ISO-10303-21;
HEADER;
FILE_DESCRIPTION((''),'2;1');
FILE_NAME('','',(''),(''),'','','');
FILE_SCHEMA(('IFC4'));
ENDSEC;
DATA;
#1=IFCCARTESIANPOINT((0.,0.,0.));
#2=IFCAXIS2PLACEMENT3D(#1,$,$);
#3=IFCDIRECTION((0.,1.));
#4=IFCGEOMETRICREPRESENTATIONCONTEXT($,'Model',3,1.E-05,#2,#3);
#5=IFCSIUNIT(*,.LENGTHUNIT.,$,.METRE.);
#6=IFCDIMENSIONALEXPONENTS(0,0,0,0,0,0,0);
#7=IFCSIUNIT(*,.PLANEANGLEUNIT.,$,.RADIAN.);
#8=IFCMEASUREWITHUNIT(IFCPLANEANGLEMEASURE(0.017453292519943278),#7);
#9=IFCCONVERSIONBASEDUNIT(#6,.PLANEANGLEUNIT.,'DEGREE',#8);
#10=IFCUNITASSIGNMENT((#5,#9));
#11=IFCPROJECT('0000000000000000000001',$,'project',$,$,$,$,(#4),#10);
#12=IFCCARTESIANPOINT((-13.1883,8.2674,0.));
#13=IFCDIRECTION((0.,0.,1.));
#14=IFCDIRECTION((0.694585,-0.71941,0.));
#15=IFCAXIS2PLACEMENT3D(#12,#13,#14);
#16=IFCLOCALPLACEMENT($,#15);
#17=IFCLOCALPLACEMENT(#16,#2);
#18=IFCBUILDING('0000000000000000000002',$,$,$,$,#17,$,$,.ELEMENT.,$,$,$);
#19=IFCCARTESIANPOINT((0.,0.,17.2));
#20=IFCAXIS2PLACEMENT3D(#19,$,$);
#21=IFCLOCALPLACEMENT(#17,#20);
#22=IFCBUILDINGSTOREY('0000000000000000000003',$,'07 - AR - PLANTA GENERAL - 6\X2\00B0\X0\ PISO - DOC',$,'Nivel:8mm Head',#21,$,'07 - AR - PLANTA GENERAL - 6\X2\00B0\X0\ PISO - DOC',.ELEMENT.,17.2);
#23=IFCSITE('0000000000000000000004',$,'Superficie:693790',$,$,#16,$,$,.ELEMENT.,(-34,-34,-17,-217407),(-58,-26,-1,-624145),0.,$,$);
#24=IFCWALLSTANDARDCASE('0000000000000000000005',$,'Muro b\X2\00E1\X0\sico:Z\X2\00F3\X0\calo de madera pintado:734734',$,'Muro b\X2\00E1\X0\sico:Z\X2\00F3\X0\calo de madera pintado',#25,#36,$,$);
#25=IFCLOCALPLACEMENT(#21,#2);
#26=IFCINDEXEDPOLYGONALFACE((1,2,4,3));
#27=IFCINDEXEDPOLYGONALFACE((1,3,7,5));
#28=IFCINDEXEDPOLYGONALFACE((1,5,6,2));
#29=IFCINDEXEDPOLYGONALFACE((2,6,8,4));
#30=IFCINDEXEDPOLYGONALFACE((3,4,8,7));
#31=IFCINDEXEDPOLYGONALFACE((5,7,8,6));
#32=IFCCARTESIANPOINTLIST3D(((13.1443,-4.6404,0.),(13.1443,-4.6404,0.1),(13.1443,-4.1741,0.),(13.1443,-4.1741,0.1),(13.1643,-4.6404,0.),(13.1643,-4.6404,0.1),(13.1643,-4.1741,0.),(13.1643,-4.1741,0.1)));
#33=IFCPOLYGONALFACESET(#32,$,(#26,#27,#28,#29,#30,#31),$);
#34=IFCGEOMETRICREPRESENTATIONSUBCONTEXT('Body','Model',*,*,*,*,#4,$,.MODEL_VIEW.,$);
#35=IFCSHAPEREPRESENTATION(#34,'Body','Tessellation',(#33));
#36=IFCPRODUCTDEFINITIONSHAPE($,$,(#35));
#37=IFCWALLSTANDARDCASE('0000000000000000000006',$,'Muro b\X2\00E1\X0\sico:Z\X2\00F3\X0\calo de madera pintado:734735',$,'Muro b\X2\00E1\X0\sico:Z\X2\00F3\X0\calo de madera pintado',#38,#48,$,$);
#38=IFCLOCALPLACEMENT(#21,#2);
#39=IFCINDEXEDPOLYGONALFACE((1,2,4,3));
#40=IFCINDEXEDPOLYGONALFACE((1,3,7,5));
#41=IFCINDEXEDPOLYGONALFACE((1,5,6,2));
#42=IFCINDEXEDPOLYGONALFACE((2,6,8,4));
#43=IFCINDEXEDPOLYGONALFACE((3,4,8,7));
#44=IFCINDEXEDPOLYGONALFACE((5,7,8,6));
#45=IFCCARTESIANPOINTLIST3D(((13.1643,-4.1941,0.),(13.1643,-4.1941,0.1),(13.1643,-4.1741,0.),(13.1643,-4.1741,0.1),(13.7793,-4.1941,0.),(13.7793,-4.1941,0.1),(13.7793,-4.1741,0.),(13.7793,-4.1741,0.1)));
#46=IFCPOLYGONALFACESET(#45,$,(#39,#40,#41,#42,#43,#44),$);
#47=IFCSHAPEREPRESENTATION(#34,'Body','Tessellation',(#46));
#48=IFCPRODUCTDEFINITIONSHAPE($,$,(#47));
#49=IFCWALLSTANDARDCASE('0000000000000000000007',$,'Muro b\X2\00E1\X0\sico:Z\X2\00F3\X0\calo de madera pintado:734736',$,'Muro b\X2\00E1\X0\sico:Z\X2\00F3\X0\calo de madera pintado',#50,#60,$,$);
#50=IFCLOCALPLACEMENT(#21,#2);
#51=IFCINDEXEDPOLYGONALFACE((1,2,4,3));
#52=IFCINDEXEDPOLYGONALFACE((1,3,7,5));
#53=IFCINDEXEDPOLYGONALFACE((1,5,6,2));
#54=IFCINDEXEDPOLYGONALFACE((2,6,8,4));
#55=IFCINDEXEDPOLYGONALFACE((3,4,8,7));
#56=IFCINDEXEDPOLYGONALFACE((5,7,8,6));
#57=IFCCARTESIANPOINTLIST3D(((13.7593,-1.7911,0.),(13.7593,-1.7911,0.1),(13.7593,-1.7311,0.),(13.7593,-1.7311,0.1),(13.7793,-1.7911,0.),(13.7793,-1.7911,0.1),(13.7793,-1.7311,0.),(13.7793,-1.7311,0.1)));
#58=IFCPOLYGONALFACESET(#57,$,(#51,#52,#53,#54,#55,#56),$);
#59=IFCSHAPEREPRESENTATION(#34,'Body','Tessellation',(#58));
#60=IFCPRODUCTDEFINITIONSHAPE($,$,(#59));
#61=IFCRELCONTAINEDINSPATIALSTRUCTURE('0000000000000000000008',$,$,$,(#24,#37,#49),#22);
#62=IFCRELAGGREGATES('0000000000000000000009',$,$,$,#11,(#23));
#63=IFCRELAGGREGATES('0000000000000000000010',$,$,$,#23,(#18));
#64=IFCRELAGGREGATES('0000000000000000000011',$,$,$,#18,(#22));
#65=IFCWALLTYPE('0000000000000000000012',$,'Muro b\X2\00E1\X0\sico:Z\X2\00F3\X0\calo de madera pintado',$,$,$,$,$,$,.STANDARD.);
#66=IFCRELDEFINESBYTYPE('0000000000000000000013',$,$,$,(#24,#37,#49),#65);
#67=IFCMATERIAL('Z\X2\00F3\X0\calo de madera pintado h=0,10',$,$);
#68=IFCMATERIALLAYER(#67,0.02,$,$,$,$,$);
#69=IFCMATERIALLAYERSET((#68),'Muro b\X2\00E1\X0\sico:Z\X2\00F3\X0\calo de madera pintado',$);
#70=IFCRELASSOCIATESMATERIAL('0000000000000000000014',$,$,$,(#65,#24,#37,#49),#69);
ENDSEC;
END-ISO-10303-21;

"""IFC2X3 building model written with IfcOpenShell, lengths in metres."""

from ifc_helpers import new_model, entity, si_unit, converted_unit, direction, frame, frame_2d, origin, place, context, subcontext, project, spatial, rectangle, extrude, material, layer, layer_set, layer_usage, type_object, element, save


model = new_model("IFC2X3")

# Units and contexts
model_context = context("Model", 3, precision=1e-05, world=origin(), true_north=direction((0.0, 1.0)))
body_context = subcontext(model_context, "Body", "Model", "MODEL_VIEW")
ifc_project = project(units=[si_unit("LENGTHUNIT", "METRE"), converted_unit("PLANEANGLEUNIT", "DEGREE", entity("IfcPlaneAngleMeasure", 0.017453292519943278), si_unit("PLANEANGLEUNIT", "RADIAN"), dimensions=[0, 0, 0, 0, 0, 0, 0])], contexts=[model_context])

# Site, building, storey
site_placement = place(None, frame((-13.1883, 8.2674, 0.0), z_axis=(0.0, 0.0, 1.0), x_axis=(0.694585, -0.71941, 0.0)))
site = spatial("IfcSite", under=ifc_project, at=site_placement, Name="Superficie:693790", CompositionType="ELEMENT", RefLatitude=(-34, -34, -17, -217407), RefLongitude=(-58, -26, -1, -624145), RefElevation=0.0)
building_placement = place(site_placement, origin())
building = spatial("IfcBuilding", under=site, at=building_placement, CompositionType="ELEMENT")
storey_placement = place(building_placement, frame((0.0, 0.0, 17.2)))
storey = spatial("IfcBuildingStorey", under=building, at=storey_placement, Name="07 - AR - PLANTA GENERAL - 6° PISO - DOC", ObjectType="Nivel:8mm Head", LongName="07 - AR - PLANTA GENERAL - 6° PISO - DOC", CompositionType="ELEMENT", Elevation=17.2)

# Walls
ifc_material_1 = material(Name="Zócalo de madera pintado h=0,10")
ifc_layer_1 = layer(ifc_material_1, 0.02)
ifc_layer_set_1 = layer_set([ifc_layer_1], Name="Muro básico:Zócalo de madera pintado")
wall_type_1 = type_object("IfcWallType", Name="Muro básico:Zócalo de madera pintado", PredefinedType="STANDARD", material=ifc_layer_set_1)
ifc_layer_usage_1 = layer_usage(ifc_layer_set_1, "AXIS2", "NEGATIVE", 0.01)
wall_1_placement = place(storey_placement, frame((13.1543, -4.1741, 0.0), z_axis=(0.0, 0.0, 1.0), x_axis=(0.0, -1.0, 0.0)))
element("IfcWallStandardCase", 1, at=wall_1_placement, inside=storey, type_object=wall_type_1, material=ifc_layer_usage_1, Name="Muro básico:Zócalo de madera pintado:734734", ObjectType="Muro básico:Zócalo de madera pintado", context=body_context, shape_type="SweptSolid", body=[
    extrude(rectangle(XDim=0.4663, YDim=0.02, at=frame_2d((0.2331, 0.0), x_axis=(-1.0, 0.0))), origin(), (0.0, 0.0, 1.0), 0.1),
])
ifc_layer_usage_2 = layer_usage(ifc_layer_set_1, "AXIS2", "NEGATIVE", 0.01)
wall_2_placement = place(storey_placement, frame((13.7793, -4.1841, 0.0), z_axis=(0.0, 0.0, 1.0), x_axis=(-1.0, 0.0, 0.0)))
element("IfcWallStandardCase", 2, at=wall_2_placement, inside=storey, type_object=wall_type_1, material=ifc_layer_usage_2, Name="Muro básico:Zócalo de madera pintado:734735", ObjectType="Muro básico:Zócalo de madera pintado", context=body_context, shape_type="SweptSolid", body=[
    extrude(rectangle(XDim=0.615, YDim=0.02, at=frame_2d((0.3075, 0.0), x_axis=(-1.0, 0.0))), origin(), (0.0, 0.0, 1.0), 0.1),
])
ifc_layer_usage_3 = layer_usage(ifc_layer_set_1, "AXIS2", "NEGATIVE", 0.01)
wall_3_placement = place(storey_placement, frame((13.7693, -1.7311, 0.0), z_axis=(0.0, 0.0, 1.0), x_axis=(0.0, -1.0, 0.0)))
element("IfcWallStandardCase", 3, at=wall_3_placement, inside=storey, type_object=wall_type_1, material=ifc_layer_usage_3, Name="Muro básico:Zócalo de madera pintado:734736", ObjectType="Muro básico:Zócalo de madera pintado", context=body_context, shape_type="SweptSolid", body=[
    extrude(rectangle(XDim=0.06, YDim=0.02, at=frame_2d((0.03, 0.0), x_axis=(-1.0, 0.0))), origin(), (0.0, 0.0, 1.0), 0.1),
])

save(model, "model.ifc")
